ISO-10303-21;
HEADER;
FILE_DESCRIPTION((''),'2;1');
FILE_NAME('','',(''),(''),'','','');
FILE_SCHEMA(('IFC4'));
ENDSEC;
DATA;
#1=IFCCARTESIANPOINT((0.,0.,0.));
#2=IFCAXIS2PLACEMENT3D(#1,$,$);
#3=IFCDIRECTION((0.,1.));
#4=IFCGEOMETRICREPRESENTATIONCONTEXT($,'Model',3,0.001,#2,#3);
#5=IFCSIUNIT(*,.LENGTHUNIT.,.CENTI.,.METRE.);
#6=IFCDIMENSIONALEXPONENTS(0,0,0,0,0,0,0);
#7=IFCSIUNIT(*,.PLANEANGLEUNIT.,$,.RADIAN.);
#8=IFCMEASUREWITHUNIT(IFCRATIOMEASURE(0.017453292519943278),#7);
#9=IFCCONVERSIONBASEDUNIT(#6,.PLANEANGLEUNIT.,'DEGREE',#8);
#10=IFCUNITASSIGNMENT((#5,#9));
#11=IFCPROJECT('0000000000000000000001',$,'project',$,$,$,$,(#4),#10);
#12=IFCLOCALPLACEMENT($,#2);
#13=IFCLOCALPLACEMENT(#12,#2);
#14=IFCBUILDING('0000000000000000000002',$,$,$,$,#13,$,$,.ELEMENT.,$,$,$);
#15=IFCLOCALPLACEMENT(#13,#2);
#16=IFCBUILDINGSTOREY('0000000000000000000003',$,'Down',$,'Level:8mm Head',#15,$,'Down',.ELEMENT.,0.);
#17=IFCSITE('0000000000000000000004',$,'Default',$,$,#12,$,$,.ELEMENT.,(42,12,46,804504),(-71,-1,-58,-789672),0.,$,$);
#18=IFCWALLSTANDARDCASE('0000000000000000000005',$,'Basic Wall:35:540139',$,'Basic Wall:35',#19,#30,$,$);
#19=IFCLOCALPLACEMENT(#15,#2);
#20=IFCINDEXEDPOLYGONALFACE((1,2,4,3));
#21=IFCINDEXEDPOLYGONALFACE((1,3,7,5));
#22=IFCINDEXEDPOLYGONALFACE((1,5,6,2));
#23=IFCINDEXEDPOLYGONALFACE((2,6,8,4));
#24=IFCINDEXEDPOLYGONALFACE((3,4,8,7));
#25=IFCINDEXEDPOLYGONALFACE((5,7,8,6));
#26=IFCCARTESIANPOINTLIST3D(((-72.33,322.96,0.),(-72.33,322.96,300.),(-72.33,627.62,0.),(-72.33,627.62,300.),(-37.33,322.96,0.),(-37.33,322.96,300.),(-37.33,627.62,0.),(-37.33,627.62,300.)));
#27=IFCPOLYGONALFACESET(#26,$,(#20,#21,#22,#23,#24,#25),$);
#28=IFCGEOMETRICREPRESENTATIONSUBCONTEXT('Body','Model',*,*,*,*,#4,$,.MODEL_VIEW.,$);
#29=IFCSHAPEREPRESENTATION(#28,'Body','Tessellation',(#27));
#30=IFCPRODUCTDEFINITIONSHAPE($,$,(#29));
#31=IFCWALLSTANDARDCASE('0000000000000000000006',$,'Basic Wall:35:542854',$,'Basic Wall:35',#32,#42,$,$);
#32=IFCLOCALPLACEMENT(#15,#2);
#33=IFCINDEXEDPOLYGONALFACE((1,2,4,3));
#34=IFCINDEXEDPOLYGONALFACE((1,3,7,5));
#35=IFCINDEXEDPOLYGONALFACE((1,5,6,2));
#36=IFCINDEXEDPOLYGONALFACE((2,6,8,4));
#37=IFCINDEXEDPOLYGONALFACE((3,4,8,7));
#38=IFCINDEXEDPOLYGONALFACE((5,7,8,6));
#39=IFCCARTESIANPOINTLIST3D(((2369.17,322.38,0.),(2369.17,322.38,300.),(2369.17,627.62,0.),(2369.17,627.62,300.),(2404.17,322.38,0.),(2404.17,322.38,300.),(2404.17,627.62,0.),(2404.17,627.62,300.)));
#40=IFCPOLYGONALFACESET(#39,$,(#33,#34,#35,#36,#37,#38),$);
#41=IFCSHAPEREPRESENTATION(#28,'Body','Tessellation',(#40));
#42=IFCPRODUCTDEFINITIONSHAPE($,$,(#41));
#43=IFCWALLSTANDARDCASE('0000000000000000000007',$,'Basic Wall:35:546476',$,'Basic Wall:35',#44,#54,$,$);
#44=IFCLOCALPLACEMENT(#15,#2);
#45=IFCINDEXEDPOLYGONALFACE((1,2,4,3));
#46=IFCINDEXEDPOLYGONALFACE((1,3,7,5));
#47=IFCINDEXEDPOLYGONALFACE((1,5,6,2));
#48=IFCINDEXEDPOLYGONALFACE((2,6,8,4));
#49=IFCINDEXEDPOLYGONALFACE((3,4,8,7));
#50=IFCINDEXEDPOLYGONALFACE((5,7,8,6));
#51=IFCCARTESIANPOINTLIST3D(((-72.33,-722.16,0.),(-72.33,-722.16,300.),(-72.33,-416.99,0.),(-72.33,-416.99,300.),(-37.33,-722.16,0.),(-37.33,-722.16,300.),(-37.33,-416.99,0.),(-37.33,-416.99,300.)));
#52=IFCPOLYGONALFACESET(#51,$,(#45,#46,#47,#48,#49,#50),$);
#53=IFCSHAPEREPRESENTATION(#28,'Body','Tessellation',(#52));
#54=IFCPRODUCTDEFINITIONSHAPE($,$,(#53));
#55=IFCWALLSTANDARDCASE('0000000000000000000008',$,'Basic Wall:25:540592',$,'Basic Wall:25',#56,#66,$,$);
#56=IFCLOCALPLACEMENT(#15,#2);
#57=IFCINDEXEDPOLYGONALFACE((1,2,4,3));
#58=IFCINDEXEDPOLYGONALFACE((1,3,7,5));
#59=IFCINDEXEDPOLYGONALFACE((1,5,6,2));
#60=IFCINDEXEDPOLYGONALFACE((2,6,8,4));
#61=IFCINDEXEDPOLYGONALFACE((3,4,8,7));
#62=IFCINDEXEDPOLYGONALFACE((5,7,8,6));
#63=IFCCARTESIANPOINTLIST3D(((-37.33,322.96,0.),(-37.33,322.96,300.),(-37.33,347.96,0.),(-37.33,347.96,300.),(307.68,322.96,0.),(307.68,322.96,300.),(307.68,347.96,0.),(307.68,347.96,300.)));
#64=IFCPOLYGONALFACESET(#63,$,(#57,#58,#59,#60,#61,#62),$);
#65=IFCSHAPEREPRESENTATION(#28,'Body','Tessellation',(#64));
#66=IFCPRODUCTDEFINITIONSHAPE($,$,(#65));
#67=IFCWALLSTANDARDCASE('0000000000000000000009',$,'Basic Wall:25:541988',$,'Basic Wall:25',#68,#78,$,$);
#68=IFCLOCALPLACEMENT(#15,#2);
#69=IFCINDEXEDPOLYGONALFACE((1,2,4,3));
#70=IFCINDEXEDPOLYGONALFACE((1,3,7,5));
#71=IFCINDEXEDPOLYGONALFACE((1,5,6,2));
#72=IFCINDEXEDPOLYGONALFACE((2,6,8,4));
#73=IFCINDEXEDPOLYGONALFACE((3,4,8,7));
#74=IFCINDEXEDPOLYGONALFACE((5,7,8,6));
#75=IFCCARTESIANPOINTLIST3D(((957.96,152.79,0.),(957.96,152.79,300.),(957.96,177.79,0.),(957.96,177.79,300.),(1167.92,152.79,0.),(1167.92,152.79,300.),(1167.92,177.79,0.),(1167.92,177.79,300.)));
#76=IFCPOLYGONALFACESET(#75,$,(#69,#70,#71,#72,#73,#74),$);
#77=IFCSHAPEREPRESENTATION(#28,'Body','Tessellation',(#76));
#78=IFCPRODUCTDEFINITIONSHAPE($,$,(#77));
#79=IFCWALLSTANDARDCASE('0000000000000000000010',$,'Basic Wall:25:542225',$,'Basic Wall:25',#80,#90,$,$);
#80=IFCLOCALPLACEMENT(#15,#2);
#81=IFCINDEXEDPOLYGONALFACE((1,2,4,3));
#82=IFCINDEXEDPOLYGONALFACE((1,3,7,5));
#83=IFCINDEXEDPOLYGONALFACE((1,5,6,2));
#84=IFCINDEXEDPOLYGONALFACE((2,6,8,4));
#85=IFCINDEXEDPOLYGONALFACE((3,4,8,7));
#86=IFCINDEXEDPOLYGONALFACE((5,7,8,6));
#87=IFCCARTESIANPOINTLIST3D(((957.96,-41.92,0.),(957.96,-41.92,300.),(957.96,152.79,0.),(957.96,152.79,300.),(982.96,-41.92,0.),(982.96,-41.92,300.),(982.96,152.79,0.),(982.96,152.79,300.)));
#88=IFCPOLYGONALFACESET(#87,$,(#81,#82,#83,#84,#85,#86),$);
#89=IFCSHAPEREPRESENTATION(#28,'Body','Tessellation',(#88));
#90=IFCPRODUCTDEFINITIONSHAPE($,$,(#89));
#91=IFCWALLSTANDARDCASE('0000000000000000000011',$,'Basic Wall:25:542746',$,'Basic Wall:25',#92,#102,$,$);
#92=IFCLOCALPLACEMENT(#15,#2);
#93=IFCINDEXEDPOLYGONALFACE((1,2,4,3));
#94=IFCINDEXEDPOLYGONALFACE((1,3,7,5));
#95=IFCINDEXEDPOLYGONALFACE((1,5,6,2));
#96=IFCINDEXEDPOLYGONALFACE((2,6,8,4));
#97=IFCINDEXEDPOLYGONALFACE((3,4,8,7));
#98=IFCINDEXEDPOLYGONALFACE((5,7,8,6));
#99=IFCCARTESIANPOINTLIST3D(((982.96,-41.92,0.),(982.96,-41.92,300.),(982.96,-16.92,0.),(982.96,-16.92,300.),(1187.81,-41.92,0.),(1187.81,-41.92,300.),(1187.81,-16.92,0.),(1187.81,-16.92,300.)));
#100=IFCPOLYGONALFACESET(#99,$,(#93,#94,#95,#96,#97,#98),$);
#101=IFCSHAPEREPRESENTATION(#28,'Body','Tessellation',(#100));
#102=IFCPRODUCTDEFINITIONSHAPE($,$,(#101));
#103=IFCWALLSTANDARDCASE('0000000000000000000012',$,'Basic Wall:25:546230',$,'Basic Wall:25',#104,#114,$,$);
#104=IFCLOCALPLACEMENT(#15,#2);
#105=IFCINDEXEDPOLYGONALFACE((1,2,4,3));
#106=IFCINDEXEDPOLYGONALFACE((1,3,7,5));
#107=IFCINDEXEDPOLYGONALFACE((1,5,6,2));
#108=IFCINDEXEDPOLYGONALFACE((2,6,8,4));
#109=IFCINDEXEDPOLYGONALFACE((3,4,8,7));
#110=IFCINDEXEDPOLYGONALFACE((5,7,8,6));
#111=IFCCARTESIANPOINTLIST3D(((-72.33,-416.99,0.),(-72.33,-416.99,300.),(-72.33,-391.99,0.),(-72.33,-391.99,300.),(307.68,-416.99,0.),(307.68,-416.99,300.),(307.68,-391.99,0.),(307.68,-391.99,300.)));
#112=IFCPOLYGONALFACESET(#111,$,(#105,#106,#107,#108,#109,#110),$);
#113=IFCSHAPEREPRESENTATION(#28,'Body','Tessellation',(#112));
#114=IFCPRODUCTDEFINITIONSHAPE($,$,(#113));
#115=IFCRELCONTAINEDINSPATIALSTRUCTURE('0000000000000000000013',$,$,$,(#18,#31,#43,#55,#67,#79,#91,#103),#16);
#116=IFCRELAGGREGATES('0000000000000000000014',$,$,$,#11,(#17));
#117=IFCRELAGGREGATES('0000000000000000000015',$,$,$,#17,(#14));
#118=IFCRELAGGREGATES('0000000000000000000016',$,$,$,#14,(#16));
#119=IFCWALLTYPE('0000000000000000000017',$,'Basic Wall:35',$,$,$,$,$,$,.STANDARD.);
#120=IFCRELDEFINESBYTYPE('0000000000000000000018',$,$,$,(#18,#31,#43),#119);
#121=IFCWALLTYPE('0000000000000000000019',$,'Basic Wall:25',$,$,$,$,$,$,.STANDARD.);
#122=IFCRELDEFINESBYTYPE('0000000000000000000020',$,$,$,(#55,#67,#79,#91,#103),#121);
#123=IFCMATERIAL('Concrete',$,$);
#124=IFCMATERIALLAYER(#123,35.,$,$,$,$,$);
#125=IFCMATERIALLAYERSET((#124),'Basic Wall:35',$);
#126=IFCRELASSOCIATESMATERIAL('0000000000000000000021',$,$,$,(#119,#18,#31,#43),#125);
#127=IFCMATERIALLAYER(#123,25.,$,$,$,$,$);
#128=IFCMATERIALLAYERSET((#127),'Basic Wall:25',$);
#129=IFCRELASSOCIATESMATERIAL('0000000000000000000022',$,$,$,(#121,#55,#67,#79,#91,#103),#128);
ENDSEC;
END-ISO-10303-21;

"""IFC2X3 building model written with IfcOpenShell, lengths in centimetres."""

from ifc_helpers import new_model, entity, si_unit, converted_unit, direction, frame, frame_2d, origin, place, context, subcontext, project, spatial, rectangle, extrude, material, layer, layer_set, layer_usage, type_object, element, save


model = new_model("IFC2X3")

# Units and contexts
model_context = context("Model", 3, precision=0.001, world=origin(), true_north=direction((0.0, 1.0)))
body_context = subcontext(model_context, "Body", "Model", "MODEL_VIEW")
ifc_project = project(units=[si_unit("LENGTHUNIT", "METRE", prefix="CENTI"), converted_unit("PLANEANGLEUNIT", "DEGREE", entity("IfcRatioMeasure", 0.017453292519943278), si_unit("PLANEANGLEUNIT", "RADIAN"), dimensions=[0, 0, 0, 0, 0, 0, 0])], contexts=[model_context])

# Site, building, storey
site_placement = place(None, origin())
site = spatial("IfcSite", under=ifc_project, at=site_placement, Name="Default", CompositionType="ELEMENT", RefLatitude=(42, 12, 46, 804504), RefLongitude=(-71, -1, -58, -789672), RefElevation=0.0)
building_placement = place(site_placement, origin())
building = spatial("IfcBuilding", under=site, at=building_placement, CompositionType="ELEMENT")
storey_placement = place(building_placement, origin())
storey = spatial("IfcBuildingStorey", under=building, at=storey_placement, Name="Down", ObjectType="Level:8mm Head", LongName="Down", CompositionType="ELEMENT", Elevation=0.0)

# Shared definitions
ifc_material = material(Name="Concrete")

# Walls
ifc_layer_1 = layer(ifc_material, 35.0)
ifc_layer_set_1 = layer_set([ifc_layer_1], Name="Basic Wall:35")
ifc_layer_usage_1 = layer_usage(ifc_layer_set_1, "AXIS2", "POSITIVE", -17.5)
wall_type_1 = type_object("IfcWallType", Name="Basic Wall:35", PredefinedType="STANDARD", material=ifc_layer_set_1)
wall_1_placement = place(storey_placement, frame((-54.83, 627.62, 0.0), z_axis=(0.0, 0.0, 1.0), x_axis=(0.0, -1.0, 0.0)))
element("IfcWallStandardCase", 1, at=wall_1_placement, inside=storey, type_object=wall_type_1, material=ifc_layer_usage_1, Name="Basic Wall:35:540139", ObjectType="Basic Wall:35", context=body_context, shape_type="SweptSolid", body=[
    extrude(rectangle(XDim=304.67, YDim=35.0, at=frame_2d((152.33, 0.0), x_axis=(-1.0, 0.0))), origin(), (0.0, 0.0, 1.0), 300.0),
])
ifc_layer_usage_2 = layer_usage(ifc_layer_set_1, "AXIS2", "NEGATIVE", 17.5)
wall_2_placement = place(storey_placement, frame((2386.67, 627.62, 0.0), z_axis=(0.0, 0.0, 1.0), x_axis=(0.0, -1.0, 0.0)))
element("IfcWallStandardCase", 2, at=wall_2_placement, inside=storey, type_object=wall_type_1, material=ifc_layer_usage_2, Name="Basic Wall:35:542854", ObjectType="Basic Wall:35", context=body_context, shape_type="SweptSolid", body=[
    extrude(rectangle(XDim=305.24, YDim=35.0, at=frame_2d((152.62, 0.0), x_axis=(-1.0, 0.0))), origin(), (0.0, 0.0, 1.0), 300.0),
])
ifc_layer_usage_3 = layer_usage(ifc_layer_set_1, "AXIS2", "POSITIVE", -17.5)
wall_3_placement = place(storey_placement, frame((-54.83, -416.99, 0.0), z_axis=(0.0, 0.0, 1.0), x_axis=(0.0, -1.0, 0.0)))
element("IfcWallStandardCase", 3, at=wall_3_placement, inside=storey, type_object=wall_type_1, material=ifc_layer_usage_3, Name="Basic Wall:35:546476", ObjectType="Basic Wall:35", context=body_context, shape_type="SweptSolid", body=[
    extrude(rectangle(XDim=305.17, YDim=35.0, at=frame_2d((152.58, 0.0), x_axis=(-1.0, 0.0))), origin(), (0.0, 0.0, 1.0), 300.0),
])
ifc_layer_2 = layer(ifc_material, 25.0)
ifc_layer_set_2 = layer_set([ifc_layer_2], Name="Basic Wall:25")
ifc_layer_usage_4 = layer_usage(ifc_layer_set_2, "AXIS2", "POSITIVE", -12.5)
wall_type_2 = type_object("IfcWallType", Name="Basic Wall:25", PredefinedType="STANDARD", material=ifc_layer_set_2)
wall_4_placement = place(storey_placement, frame((-37.33, 335.46, 0.0)))
element("IfcWallStandardCase", 4, at=wall_4_placement, inside=storey, type_object=wall_type_2, material=ifc_layer_usage_4, Name="Basic Wall:25:540592", ObjectType="Basic Wall:25", context=body_context, shape_type="SweptSolid", body=[
    extrude(rectangle(XDim=345.01, YDim=25.0, at=frame_2d((172.51, 0.0), x_axis=(-1.0, 0.0))), origin(), (0.0, 0.0, 1.0), 300.0),
])
ifc_layer_usage_5 = layer_usage(ifc_layer_set_2, "AXIS2", "NEGATIVE", 12.5)
wall_5_placement = place(storey_placement, frame((1167.92, 165.29, 0.0), z_axis=(0.0, 0.0, 1.0), x_axis=(-1.0, 0.0, 0.0)))
element("IfcWallStandardCase", 5, at=wall_5_placement, inside=storey, type_object=wall_type_2, material=ifc_layer_usage_5, Name="Basic Wall:25:541988", ObjectType="Basic Wall:25", context=body_context, shape_type="SweptSolid", body=[
    extrude(rectangle(XDim=209.95, YDim=25.0, at=frame_2d((104.98, 0.0), x_axis=(-1.0, 0.0))), origin(), (0.0, 0.0, 1.0), 300.0),
])
ifc_layer_usage_6 = layer_usage(ifc_layer_set_2, "AXIS2", "POSITIVE", -12.5)
wall_6_placement = place(storey_placement, frame((970.46, 152.79, 0.0), z_axis=(0.0, 0.0, 1.0), x_axis=(0.0, -1.0, 0.0)))
element("IfcWallStandardCase", 6, at=wall_6_placement, inside=storey, type_object=wall_type_2, material=ifc_layer_usage_6, Name="Basic Wall:25:542225", ObjectType="Basic Wall:25", context=body_context, shape_type="SweptSolid", body=[
    extrude(rectangle(XDim=194.72, YDim=25.0, at=frame_2d((97.36, 0.0), x_axis=(-1.0, 0.0))), origin(), (0.0, 0.0, 1.0), 300.0),
])
ifc_layer_usage_7 = layer_usage(ifc_layer_set_2, "AXIS2", "POSITIVE", -12.5)
wall_7_placement = place(storey_placement, frame((982.96, -29.42, 0.0)))
element("IfcWallStandardCase", 7, at=wall_7_placement, inside=storey, type_object=wall_type_2, material=ifc_layer_usage_7, Name="Basic Wall:25:542746", ObjectType="Basic Wall:25", context=body_context, shape_type="SweptSolid", body=[
    extrude(rectangle(XDim=204.85, YDim=25.0, at=frame_2d((102.42, 0.0), x_axis=(-1.0, 0.0))), origin(), (0.0, 0.0, 1.0), 300.0),
])
ifc_layer_usage_8 = layer_usage(ifc_layer_set_2, "AXIS2", "POSITIVE", -12.5)
wall_8_placement = place(storey_placement, frame((307.68, -404.49, 0.0), z_axis=(0.0, 0.0, 1.0), x_axis=(-1.0, 0.0, 0.0)))
element("IfcWallStandardCase", 8, at=wall_8_placement, inside=storey, type_object=wall_type_2, material=ifc_layer_usage_8, Name="Basic Wall:25:546230", ObjectType="Basic Wall:25", context=body_context, shape_type="SweptSolid", body=[
    extrude(rectangle(XDim=380.01, YDim=25.0, at=frame_2d((190.01, 0.0), x_axis=(-1.0, 0.0))), origin(), (0.0, 0.0, 1.0), 300.0),
])

save(model, "model.ifc")
